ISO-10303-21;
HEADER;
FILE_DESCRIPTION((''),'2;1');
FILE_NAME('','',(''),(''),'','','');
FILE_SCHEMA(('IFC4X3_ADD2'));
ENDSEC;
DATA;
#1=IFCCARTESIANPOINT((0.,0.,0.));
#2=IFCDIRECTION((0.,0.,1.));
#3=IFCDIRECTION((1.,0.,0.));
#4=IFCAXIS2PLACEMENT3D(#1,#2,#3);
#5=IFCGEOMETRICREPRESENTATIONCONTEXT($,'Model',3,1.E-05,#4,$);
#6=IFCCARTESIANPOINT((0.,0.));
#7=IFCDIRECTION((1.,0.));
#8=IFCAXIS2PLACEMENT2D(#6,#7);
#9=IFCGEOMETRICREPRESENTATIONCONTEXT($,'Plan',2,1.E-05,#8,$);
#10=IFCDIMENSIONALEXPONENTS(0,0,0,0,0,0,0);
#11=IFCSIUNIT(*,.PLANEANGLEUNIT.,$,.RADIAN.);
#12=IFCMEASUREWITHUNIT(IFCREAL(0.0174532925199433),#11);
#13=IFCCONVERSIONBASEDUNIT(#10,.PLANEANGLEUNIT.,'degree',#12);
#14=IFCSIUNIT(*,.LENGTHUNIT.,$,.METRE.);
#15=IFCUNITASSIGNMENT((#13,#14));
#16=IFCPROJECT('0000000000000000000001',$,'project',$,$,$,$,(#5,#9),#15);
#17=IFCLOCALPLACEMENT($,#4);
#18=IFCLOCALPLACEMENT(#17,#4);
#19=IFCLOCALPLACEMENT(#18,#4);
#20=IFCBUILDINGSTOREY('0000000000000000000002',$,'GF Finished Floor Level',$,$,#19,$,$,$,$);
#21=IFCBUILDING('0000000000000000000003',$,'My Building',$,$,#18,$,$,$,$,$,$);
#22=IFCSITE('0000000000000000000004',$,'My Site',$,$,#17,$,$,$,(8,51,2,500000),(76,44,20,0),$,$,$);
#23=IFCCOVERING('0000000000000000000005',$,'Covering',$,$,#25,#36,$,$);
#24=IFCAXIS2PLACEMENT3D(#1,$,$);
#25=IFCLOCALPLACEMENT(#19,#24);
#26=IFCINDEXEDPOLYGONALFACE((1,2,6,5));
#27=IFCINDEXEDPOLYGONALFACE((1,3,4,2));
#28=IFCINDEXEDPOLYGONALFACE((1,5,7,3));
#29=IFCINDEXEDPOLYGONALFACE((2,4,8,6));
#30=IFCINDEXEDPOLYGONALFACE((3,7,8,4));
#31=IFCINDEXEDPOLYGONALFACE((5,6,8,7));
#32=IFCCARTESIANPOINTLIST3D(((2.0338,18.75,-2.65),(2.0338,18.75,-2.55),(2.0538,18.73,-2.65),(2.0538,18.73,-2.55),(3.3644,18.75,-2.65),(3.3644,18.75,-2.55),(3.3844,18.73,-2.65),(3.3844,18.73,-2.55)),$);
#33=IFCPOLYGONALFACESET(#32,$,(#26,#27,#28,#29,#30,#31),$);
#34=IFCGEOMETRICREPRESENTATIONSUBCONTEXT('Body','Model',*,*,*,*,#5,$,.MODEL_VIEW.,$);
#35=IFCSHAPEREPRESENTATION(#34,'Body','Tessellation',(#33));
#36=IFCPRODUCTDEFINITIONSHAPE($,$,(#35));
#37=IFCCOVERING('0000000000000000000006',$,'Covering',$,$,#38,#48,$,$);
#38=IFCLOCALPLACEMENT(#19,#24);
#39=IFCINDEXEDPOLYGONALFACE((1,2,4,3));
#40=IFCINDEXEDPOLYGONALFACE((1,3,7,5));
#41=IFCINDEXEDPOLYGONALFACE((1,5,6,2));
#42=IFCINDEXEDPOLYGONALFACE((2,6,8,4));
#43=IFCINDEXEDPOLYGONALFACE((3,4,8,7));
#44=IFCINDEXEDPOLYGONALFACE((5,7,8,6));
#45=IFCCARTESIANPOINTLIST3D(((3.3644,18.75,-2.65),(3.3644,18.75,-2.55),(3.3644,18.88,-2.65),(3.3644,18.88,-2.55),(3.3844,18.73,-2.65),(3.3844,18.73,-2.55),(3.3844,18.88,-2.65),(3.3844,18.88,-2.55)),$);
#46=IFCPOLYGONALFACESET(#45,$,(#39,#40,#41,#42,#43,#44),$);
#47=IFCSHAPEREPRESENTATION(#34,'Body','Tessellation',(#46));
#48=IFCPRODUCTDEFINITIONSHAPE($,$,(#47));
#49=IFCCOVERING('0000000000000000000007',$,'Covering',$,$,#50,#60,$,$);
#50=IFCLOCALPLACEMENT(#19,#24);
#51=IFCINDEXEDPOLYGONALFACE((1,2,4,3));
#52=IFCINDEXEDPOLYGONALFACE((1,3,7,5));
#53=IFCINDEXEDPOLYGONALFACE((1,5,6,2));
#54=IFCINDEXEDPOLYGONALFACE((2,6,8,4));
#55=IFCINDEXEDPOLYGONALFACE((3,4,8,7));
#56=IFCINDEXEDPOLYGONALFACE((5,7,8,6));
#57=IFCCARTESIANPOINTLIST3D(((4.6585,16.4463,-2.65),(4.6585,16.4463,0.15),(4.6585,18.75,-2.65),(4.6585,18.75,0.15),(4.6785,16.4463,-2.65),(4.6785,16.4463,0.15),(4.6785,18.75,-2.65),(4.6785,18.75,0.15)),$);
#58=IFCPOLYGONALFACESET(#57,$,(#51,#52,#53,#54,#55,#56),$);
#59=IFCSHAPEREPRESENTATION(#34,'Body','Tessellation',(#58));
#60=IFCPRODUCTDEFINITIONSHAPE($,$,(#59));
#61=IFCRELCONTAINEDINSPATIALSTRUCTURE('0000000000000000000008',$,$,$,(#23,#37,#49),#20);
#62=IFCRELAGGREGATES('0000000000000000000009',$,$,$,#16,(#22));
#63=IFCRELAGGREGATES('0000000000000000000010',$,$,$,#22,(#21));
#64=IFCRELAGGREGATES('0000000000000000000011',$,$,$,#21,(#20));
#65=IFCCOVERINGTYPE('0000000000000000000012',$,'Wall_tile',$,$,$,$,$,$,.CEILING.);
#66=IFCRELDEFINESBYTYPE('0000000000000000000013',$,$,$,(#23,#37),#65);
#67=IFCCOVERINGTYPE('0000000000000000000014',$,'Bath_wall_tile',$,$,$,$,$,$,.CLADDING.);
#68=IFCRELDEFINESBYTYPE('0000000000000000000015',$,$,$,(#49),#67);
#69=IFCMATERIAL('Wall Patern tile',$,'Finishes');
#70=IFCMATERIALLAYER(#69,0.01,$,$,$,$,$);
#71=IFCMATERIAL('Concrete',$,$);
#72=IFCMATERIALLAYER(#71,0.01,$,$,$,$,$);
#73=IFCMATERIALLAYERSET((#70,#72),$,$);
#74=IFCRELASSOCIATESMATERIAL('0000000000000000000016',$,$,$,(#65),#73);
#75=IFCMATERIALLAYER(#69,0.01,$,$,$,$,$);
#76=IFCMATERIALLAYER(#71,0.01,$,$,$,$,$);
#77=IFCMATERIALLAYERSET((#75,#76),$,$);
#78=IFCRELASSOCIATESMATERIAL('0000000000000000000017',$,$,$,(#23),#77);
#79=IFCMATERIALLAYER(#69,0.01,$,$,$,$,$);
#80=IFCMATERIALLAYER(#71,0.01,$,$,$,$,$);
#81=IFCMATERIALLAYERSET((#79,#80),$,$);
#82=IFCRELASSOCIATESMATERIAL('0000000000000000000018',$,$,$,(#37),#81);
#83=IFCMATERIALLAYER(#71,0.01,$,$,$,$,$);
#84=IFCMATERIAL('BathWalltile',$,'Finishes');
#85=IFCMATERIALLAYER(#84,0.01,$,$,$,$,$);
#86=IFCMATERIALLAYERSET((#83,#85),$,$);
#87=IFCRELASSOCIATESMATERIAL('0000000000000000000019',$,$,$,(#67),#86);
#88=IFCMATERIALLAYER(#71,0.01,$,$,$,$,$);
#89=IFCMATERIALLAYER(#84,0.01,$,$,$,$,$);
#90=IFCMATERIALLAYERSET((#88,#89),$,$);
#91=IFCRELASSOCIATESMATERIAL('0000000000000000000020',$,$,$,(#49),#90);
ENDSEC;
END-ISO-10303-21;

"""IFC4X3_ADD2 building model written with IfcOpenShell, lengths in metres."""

from ifc_helpers import new_model, entity, si_unit, converted_unit, frame, origin_with_axes, origin_2d_with_axis, place, context, subcontext, project, spatial, line, indexed_curve, outline, extrude, material, layer, layer_set, layer_usage, type_object, element, save


model = new_model("IFC4X3_ADD2")

# Units and contexts
model_context = context("Model", 3, precision=1e-05, world=origin_with_axes())
plan_context = context("Plan", 2, precision=1e-05, world=origin_2d_with_axis())
body_context_1 = subcontext(model_context, "Body", "Model", "MODEL_VIEW")
ifc_project = project(units=[converted_unit("PLANEANGLEUNIT", "degree", entity("IfcReal", 0.0174532925199433), si_unit("PLANEANGLEUNIT", "RADIAN"), dimensions=[0, 0, 0, 0, 0, 0, 0]), si_unit("LENGTHUNIT", "METRE")], contexts=[model_context, plan_context])

# Site, building, storey
site_placement = place(None, origin_with_axes())
site = spatial("IfcSite", under=ifc_project, at=site_placement, Name="My Site", RefLatitude=(8, 51, 2, 500000), RefLongitude=(76, 44, 20, 0))
building_placement = place(site_placement, origin_with_axes())
building = spatial("IfcBuilding", under=site, at=building_placement, Name="My Building")
storey_placement = place(building_placement, origin_with_axes())
storey = spatial("IfcBuildingStorey", under=building, at=storey_placement, Name="GF Finished Floor Level")

# Coverings
ifc_material_1 = material(Name="Wall Patern tile", Category="Finishes")
ifc_material_2 = material(Name="Concrete")
ifc_layer_1 = layer(ifc_material_1, 0.01)
ifc_layer_2 = layer(ifc_material_2, 0.01)
ifc_layer_set_1 = layer_set([ifc_layer_1, ifc_layer_2])
covering_type_1 = type_object("IfcCoveringType", Name="Wall_tile", PredefinedType="CEILING", material=ifc_layer_set_1)
ifc_layer_3 = layer(ifc_material_1, 0.01)
ifc_layer_4 = layer(ifc_material_2, 0.01)
ifc_layer_set_2 = layer_set([ifc_layer_3, ifc_layer_4])
ifc_layer_usage_1 = layer_usage(ifc_layer_set_2, "AXIS2", "NEGATIVE", 0.0)
covering_1_placement = place(storey_placement, frame((3.3844, 18.73, -2.65), z_axis=(0.0, 0.0, 1.0), x_axis=(-1.0, 0.0, 0.0)))
element("IfcCovering", 1, at=covering_1_placement, inside=storey, type_object=covering_type_1, material=ifc_layer_usage_1, Name="Covering", context=body_context_1, shape_type="SweptSolid", body=[
    extrude(outline(indexed_curve([(0.02, -0.02), (0.0, 0.0), (1.3306, 0.0), (1.3506, -0.02)], segments=[line(1, 2, 3, 4, 1)])), origin_with_axes(), (0.0, 0.0, 1.0), 0.1),
])
ifc_layer_5 = layer(ifc_material_1, 0.01)
ifc_layer_6 = layer(ifc_material_2, 0.01)
ifc_layer_set_3 = layer_set([ifc_layer_5, ifc_layer_6])
ifc_layer_usage_2 = layer_usage(ifc_layer_set_3, "AXIS2", "POSITIVE", 0.0)
covering_2_placement = place(storey_placement, frame((3.3844, 18.73, -2.65), z_axis=(0.0, 0.0, 1.0), x_axis=(0.0, 1.0, 0.0)))
element("IfcCovering", 2, at=covering_2_placement, inside=storey, type_object=covering_type_1, material=ifc_layer_usage_2, Name="Covering", context=body_context_1, shape_type="SweptSolid", body=[
    extrude(outline(indexed_curve([(0.0, 0.0), (0.02, 0.02), (0.15, 0.02), (0.15, 0.0)], segments=[line(1, 2, 3, 4, 1)])), origin_with_axes(), (0.0, 0.0, 1.0), 0.1),
])
ifc_layer_7 = layer(ifc_material_2, 0.01)
ifc_material_3 = material(Name="BathWalltile", Category="Finishes")
ifc_layer_8 = layer(ifc_material_3, 0.01)
ifc_layer_set_4 = layer_set([ifc_layer_7, ifc_layer_8])
ifc_layer_usage_3 = layer_usage(ifc_layer_set_4, "AXIS2", "POSITIVE", 0.0)
ifc_layer_9 = layer(ifc_material_2, 0.01)
ifc_layer_10 = layer(ifc_material_3, 0.01)
ifc_layer_set_5 = layer_set([ifc_layer_9, ifc_layer_10])
covering_type_2 = type_object("IfcCoveringType", Name="Bath_wall_tile", PredefinedType="CLADDING", material=ifc_layer_set_5)
covering_3_placement = place(storey_placement, frame((4.6585, 18.75, -2.65), z_axis=(0.0, 0.0, 1.0), x_axis=(0.0, -1.0, 0.0)))
element("IfcCovering", 3, at=covering_3_placement, inside=storey, type_object=covering_type_2, material=ifc_layer_usage_3, Name="Covering", context=body_context_1, shape_type="SweptSolid", body=[
    extrude(outline(indexed_curve([(0.0, 0.0), (0.0, 0.02), (2.3037, 0.02), (2.3037, 0.0)], segments=[line(1, 2, 3, 4, 1)])), origin_with_axes(), (0.0, 0.0, 1.0), 2.8),
])

save(model, "model.ifc")
